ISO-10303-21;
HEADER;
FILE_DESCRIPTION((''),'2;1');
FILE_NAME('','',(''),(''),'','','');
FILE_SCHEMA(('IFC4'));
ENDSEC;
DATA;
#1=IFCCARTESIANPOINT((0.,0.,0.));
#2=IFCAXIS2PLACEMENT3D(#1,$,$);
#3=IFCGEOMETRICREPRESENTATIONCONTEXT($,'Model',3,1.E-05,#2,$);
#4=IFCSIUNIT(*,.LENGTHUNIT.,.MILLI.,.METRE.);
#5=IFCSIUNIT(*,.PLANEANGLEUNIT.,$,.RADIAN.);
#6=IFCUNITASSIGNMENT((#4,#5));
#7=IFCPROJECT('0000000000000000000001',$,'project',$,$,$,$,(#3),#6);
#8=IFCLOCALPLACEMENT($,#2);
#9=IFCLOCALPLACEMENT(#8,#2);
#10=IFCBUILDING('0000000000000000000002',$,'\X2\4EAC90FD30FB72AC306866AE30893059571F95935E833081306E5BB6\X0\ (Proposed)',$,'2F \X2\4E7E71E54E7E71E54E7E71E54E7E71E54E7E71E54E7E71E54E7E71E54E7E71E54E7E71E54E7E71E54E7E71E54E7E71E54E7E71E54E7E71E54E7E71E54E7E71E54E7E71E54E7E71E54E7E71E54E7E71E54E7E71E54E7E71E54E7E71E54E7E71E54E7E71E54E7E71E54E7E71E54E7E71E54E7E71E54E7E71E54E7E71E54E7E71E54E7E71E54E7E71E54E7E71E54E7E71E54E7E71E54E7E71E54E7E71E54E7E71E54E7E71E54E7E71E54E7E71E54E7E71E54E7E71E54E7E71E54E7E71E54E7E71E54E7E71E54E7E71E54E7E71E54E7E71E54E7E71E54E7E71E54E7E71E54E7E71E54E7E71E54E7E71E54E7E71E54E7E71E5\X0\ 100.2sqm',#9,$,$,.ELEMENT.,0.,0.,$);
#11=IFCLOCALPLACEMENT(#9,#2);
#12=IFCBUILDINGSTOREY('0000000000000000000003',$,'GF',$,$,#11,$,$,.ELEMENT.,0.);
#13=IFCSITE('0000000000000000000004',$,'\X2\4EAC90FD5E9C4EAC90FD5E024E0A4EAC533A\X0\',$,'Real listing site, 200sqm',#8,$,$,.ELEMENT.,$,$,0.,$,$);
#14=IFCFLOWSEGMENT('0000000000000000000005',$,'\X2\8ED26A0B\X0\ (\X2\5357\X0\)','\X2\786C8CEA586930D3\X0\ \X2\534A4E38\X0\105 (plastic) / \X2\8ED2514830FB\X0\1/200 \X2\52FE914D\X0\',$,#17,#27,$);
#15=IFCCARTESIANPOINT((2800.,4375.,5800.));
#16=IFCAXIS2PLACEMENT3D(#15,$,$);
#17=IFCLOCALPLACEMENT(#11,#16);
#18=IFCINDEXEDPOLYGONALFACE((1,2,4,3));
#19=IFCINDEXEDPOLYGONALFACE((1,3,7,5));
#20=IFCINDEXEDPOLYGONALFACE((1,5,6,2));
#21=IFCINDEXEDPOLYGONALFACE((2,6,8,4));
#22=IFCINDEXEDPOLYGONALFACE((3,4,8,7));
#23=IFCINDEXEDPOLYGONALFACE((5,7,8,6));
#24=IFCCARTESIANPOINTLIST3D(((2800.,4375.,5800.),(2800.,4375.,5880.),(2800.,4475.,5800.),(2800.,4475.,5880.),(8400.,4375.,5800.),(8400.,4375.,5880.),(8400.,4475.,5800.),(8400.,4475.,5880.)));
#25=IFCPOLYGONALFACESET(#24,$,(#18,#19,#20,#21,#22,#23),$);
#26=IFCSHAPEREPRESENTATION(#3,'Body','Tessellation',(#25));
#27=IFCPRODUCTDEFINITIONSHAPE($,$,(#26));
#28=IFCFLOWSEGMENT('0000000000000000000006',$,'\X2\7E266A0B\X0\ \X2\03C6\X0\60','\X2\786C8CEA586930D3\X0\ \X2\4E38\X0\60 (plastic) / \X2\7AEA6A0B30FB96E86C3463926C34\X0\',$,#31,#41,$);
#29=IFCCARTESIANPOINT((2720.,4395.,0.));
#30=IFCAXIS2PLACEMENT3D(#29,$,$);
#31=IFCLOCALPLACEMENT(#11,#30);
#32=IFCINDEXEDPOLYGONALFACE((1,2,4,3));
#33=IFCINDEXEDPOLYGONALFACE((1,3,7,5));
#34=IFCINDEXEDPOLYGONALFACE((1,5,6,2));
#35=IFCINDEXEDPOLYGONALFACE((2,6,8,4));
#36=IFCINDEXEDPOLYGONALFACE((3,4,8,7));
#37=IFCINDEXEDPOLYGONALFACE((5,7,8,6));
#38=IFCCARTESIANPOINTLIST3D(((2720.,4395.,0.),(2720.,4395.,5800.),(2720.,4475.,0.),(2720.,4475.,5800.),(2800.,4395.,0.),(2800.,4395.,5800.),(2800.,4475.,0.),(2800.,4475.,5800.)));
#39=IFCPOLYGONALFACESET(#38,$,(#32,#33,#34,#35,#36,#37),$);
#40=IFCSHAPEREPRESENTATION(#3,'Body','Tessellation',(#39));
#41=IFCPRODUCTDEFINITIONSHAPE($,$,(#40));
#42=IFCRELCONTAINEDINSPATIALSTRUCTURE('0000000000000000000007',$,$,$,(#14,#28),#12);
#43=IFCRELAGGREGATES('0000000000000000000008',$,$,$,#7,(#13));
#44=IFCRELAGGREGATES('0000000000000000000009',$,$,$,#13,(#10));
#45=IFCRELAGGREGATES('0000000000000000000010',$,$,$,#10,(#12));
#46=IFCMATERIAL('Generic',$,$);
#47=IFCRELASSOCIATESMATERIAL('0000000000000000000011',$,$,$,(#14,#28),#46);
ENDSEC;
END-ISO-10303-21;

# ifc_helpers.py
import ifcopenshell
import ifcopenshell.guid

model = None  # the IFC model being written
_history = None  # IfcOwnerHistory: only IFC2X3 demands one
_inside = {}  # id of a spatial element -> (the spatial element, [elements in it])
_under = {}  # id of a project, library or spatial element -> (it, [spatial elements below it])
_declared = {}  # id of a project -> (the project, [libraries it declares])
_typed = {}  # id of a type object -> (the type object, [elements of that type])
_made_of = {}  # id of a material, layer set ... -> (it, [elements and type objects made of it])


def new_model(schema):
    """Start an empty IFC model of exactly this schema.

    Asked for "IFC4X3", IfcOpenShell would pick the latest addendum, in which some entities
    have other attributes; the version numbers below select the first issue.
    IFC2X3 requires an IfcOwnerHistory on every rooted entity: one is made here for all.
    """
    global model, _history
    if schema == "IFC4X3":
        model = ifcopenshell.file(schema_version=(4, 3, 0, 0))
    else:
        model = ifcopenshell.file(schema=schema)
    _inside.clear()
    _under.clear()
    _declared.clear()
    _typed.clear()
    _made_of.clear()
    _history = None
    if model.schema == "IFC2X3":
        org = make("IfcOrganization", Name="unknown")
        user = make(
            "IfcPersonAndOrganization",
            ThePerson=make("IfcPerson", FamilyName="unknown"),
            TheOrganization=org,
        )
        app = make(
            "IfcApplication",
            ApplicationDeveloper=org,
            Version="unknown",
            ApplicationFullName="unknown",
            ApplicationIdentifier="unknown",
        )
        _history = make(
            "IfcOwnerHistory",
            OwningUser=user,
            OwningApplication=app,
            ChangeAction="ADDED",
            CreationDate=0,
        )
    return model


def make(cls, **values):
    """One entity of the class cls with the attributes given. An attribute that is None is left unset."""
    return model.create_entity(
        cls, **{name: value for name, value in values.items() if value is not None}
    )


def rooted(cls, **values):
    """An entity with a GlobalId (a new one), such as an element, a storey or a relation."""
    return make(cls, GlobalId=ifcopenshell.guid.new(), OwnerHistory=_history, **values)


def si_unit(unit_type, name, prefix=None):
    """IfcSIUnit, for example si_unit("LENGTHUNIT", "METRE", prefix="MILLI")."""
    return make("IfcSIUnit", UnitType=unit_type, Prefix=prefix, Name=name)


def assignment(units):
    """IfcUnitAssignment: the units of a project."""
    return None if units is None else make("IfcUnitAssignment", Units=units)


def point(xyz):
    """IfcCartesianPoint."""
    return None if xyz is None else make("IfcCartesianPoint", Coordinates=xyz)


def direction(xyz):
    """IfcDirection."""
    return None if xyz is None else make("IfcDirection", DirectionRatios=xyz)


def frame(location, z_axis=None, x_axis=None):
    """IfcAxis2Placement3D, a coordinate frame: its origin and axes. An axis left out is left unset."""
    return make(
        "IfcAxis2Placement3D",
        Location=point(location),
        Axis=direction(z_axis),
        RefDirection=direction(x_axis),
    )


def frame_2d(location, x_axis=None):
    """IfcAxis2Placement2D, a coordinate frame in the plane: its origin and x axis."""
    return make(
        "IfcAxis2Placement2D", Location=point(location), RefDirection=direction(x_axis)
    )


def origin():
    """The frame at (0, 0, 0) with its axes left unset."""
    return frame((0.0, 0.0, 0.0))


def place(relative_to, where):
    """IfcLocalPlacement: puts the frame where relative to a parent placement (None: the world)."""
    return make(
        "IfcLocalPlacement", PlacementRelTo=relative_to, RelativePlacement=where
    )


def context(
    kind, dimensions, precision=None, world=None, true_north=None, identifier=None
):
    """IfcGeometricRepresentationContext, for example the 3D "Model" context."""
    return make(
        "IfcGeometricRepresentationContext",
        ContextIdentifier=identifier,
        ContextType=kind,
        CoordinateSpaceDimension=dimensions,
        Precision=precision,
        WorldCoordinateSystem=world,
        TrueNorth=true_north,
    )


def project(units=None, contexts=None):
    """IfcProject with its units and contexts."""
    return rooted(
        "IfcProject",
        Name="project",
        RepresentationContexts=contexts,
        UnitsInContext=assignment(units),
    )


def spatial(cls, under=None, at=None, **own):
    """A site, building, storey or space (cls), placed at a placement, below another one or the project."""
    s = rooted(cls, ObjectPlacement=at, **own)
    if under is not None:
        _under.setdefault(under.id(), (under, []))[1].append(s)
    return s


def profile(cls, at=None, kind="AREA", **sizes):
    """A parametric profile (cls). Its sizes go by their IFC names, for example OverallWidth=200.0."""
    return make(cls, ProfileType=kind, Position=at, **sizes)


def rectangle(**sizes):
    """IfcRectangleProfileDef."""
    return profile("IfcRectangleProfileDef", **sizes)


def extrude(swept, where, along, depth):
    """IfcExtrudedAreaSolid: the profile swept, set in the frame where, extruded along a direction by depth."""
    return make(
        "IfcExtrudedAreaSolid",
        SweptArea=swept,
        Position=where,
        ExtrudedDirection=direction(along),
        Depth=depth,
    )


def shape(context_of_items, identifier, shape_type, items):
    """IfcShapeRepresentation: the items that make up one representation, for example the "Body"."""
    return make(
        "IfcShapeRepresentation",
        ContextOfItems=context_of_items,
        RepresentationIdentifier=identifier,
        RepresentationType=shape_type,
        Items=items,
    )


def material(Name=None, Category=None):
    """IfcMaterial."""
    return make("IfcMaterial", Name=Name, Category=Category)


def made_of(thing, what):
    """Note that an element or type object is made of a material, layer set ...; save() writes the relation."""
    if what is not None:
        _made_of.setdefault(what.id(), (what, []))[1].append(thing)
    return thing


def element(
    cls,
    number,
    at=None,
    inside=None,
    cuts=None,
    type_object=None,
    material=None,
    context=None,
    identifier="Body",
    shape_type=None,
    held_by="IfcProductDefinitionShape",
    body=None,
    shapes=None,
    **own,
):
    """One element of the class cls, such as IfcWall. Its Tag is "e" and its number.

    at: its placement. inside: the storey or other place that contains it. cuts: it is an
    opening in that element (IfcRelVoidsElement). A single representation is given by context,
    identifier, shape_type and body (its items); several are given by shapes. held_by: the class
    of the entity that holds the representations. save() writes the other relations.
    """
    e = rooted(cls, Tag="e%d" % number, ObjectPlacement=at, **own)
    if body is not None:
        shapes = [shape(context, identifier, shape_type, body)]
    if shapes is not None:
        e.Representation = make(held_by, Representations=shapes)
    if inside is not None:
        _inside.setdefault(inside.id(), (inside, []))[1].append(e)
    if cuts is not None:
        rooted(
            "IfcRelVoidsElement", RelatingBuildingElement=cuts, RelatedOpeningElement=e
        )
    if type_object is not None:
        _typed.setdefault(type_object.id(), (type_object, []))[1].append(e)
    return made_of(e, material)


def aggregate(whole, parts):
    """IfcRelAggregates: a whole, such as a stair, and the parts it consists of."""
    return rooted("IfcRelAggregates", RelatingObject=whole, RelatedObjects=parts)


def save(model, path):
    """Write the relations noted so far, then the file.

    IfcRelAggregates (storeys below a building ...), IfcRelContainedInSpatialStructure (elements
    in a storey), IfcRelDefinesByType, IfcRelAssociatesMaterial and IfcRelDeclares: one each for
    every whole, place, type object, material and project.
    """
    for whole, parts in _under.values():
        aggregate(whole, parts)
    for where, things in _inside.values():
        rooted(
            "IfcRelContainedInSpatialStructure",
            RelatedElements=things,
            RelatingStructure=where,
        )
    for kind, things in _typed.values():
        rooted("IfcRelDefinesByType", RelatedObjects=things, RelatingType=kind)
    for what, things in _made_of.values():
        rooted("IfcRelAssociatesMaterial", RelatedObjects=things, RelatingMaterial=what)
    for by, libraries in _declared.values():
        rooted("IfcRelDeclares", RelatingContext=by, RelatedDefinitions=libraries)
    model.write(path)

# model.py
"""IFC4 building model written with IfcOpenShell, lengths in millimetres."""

from ifc_helpers import new_model, si_unit, frame, frame_2d, origin, place, context, project, spatial, rectangle, extrude, material, element, save


model = new_model("IFC4")

# Units and contexts
model_context = context("Model", 3, precision=1e-05, world=origin())
ifc_project = project(units=[si_unit("LENGTHUNIT", "METRE", prefix="MILLI"), si_unit("PLANEANGLEUNIT", "RADIAN")], contexts=[model_context])

# Site, building, storey
site_placement = place(None, origin())
site = spatial("IfcSite", under=ifc_project, at=site_placement, Name="京都府京都市上京区", ObjectType="Real listing site, 200sqm", CompositionType="ELEMENT", RefElevation=0.0)
building_placement = place(site_placement, origin())
building = spatial("IfcBuilding", under=site, at=building_placement, Name="京都・犬と暮らす土間広めの家 (Proposed)", ObjectType="2F 乾燥乾燥乾燥乾燥乾燥乾燥乾燥乾燥乾燥乾燥乾燥乾燥乾燥乾燥乾燥乾燥乾燥乾燥乾燥乾燥乾燥乾燥乾燥乾燥乾燥乾燥乾燥乾燥乾燥乾燥乾燥乾燥乾燥乾燥乾燥乾燥乾燥乾燥乾燥乾燥乾燥乾燥乾燥乾燥乾燥乾燥乾燥乾燥乾燥乾燥乾燥乾燥乾燥乾燥乾燥乾燥乾燥乾燥乾燥乾燥 100.2sqm", CompositionType="ELEMENT", ElevationOfRefHeight=0.0, ElevationOfTerrain=0.0)
storey_placement = place(building_placement, origin())
storey = spatial("IfcBuildingStorey", under=building, at=storey_placement, Name="GF", CompositionType="ELEMENT", Elevation=0.0)

# Flow segments
ifc_material_1 = material(Name="Generic")
flow_segment_1_placement = place(storey_placement, frame((2800.0, 4375.0, 5800.0)))
element("IfcFlowSegment", 1, at=flow_segment_1_placement, inside=storey, material=ifc_material_1, Name="軒樋 (南)", Description="硬質塩ビ 半丸105 (plastic) / 軒先・1/200 勾配", context=model_context, shape_type="SweptSolid", body=[
    extrude(rectangle(XDim=5600.0, YDim=100.0, at=frame_2d((2800.0, 50.0))), frame((2800.0, 4375.0, 5800.0)), (0.0, 0.0, 1.0), 80.0),
])
flow_segment_2_placement = place(storey_placement, frame((2720.0, 4395.0, 0.0)))
element("IfcFlowSegment", 2, at=flow_segment_2_placement, inside=storey, material=ifc_material_1, Name="縦樋 φ60", Description="硬質塩ビ 丸60 (plastic) / 竪樋・雨水排水", context=model_context, shape_type="SweptSolid", body=[
    extrude(rectangle(XDim=80.0, YDim=80.0, at=frame_2d((40.0, 40.0))), frame((2720.0, 4395.0, 0.0)), (0.0, 0.0, 1.0), 5800.0),
])

save(model, "model.ifc")
